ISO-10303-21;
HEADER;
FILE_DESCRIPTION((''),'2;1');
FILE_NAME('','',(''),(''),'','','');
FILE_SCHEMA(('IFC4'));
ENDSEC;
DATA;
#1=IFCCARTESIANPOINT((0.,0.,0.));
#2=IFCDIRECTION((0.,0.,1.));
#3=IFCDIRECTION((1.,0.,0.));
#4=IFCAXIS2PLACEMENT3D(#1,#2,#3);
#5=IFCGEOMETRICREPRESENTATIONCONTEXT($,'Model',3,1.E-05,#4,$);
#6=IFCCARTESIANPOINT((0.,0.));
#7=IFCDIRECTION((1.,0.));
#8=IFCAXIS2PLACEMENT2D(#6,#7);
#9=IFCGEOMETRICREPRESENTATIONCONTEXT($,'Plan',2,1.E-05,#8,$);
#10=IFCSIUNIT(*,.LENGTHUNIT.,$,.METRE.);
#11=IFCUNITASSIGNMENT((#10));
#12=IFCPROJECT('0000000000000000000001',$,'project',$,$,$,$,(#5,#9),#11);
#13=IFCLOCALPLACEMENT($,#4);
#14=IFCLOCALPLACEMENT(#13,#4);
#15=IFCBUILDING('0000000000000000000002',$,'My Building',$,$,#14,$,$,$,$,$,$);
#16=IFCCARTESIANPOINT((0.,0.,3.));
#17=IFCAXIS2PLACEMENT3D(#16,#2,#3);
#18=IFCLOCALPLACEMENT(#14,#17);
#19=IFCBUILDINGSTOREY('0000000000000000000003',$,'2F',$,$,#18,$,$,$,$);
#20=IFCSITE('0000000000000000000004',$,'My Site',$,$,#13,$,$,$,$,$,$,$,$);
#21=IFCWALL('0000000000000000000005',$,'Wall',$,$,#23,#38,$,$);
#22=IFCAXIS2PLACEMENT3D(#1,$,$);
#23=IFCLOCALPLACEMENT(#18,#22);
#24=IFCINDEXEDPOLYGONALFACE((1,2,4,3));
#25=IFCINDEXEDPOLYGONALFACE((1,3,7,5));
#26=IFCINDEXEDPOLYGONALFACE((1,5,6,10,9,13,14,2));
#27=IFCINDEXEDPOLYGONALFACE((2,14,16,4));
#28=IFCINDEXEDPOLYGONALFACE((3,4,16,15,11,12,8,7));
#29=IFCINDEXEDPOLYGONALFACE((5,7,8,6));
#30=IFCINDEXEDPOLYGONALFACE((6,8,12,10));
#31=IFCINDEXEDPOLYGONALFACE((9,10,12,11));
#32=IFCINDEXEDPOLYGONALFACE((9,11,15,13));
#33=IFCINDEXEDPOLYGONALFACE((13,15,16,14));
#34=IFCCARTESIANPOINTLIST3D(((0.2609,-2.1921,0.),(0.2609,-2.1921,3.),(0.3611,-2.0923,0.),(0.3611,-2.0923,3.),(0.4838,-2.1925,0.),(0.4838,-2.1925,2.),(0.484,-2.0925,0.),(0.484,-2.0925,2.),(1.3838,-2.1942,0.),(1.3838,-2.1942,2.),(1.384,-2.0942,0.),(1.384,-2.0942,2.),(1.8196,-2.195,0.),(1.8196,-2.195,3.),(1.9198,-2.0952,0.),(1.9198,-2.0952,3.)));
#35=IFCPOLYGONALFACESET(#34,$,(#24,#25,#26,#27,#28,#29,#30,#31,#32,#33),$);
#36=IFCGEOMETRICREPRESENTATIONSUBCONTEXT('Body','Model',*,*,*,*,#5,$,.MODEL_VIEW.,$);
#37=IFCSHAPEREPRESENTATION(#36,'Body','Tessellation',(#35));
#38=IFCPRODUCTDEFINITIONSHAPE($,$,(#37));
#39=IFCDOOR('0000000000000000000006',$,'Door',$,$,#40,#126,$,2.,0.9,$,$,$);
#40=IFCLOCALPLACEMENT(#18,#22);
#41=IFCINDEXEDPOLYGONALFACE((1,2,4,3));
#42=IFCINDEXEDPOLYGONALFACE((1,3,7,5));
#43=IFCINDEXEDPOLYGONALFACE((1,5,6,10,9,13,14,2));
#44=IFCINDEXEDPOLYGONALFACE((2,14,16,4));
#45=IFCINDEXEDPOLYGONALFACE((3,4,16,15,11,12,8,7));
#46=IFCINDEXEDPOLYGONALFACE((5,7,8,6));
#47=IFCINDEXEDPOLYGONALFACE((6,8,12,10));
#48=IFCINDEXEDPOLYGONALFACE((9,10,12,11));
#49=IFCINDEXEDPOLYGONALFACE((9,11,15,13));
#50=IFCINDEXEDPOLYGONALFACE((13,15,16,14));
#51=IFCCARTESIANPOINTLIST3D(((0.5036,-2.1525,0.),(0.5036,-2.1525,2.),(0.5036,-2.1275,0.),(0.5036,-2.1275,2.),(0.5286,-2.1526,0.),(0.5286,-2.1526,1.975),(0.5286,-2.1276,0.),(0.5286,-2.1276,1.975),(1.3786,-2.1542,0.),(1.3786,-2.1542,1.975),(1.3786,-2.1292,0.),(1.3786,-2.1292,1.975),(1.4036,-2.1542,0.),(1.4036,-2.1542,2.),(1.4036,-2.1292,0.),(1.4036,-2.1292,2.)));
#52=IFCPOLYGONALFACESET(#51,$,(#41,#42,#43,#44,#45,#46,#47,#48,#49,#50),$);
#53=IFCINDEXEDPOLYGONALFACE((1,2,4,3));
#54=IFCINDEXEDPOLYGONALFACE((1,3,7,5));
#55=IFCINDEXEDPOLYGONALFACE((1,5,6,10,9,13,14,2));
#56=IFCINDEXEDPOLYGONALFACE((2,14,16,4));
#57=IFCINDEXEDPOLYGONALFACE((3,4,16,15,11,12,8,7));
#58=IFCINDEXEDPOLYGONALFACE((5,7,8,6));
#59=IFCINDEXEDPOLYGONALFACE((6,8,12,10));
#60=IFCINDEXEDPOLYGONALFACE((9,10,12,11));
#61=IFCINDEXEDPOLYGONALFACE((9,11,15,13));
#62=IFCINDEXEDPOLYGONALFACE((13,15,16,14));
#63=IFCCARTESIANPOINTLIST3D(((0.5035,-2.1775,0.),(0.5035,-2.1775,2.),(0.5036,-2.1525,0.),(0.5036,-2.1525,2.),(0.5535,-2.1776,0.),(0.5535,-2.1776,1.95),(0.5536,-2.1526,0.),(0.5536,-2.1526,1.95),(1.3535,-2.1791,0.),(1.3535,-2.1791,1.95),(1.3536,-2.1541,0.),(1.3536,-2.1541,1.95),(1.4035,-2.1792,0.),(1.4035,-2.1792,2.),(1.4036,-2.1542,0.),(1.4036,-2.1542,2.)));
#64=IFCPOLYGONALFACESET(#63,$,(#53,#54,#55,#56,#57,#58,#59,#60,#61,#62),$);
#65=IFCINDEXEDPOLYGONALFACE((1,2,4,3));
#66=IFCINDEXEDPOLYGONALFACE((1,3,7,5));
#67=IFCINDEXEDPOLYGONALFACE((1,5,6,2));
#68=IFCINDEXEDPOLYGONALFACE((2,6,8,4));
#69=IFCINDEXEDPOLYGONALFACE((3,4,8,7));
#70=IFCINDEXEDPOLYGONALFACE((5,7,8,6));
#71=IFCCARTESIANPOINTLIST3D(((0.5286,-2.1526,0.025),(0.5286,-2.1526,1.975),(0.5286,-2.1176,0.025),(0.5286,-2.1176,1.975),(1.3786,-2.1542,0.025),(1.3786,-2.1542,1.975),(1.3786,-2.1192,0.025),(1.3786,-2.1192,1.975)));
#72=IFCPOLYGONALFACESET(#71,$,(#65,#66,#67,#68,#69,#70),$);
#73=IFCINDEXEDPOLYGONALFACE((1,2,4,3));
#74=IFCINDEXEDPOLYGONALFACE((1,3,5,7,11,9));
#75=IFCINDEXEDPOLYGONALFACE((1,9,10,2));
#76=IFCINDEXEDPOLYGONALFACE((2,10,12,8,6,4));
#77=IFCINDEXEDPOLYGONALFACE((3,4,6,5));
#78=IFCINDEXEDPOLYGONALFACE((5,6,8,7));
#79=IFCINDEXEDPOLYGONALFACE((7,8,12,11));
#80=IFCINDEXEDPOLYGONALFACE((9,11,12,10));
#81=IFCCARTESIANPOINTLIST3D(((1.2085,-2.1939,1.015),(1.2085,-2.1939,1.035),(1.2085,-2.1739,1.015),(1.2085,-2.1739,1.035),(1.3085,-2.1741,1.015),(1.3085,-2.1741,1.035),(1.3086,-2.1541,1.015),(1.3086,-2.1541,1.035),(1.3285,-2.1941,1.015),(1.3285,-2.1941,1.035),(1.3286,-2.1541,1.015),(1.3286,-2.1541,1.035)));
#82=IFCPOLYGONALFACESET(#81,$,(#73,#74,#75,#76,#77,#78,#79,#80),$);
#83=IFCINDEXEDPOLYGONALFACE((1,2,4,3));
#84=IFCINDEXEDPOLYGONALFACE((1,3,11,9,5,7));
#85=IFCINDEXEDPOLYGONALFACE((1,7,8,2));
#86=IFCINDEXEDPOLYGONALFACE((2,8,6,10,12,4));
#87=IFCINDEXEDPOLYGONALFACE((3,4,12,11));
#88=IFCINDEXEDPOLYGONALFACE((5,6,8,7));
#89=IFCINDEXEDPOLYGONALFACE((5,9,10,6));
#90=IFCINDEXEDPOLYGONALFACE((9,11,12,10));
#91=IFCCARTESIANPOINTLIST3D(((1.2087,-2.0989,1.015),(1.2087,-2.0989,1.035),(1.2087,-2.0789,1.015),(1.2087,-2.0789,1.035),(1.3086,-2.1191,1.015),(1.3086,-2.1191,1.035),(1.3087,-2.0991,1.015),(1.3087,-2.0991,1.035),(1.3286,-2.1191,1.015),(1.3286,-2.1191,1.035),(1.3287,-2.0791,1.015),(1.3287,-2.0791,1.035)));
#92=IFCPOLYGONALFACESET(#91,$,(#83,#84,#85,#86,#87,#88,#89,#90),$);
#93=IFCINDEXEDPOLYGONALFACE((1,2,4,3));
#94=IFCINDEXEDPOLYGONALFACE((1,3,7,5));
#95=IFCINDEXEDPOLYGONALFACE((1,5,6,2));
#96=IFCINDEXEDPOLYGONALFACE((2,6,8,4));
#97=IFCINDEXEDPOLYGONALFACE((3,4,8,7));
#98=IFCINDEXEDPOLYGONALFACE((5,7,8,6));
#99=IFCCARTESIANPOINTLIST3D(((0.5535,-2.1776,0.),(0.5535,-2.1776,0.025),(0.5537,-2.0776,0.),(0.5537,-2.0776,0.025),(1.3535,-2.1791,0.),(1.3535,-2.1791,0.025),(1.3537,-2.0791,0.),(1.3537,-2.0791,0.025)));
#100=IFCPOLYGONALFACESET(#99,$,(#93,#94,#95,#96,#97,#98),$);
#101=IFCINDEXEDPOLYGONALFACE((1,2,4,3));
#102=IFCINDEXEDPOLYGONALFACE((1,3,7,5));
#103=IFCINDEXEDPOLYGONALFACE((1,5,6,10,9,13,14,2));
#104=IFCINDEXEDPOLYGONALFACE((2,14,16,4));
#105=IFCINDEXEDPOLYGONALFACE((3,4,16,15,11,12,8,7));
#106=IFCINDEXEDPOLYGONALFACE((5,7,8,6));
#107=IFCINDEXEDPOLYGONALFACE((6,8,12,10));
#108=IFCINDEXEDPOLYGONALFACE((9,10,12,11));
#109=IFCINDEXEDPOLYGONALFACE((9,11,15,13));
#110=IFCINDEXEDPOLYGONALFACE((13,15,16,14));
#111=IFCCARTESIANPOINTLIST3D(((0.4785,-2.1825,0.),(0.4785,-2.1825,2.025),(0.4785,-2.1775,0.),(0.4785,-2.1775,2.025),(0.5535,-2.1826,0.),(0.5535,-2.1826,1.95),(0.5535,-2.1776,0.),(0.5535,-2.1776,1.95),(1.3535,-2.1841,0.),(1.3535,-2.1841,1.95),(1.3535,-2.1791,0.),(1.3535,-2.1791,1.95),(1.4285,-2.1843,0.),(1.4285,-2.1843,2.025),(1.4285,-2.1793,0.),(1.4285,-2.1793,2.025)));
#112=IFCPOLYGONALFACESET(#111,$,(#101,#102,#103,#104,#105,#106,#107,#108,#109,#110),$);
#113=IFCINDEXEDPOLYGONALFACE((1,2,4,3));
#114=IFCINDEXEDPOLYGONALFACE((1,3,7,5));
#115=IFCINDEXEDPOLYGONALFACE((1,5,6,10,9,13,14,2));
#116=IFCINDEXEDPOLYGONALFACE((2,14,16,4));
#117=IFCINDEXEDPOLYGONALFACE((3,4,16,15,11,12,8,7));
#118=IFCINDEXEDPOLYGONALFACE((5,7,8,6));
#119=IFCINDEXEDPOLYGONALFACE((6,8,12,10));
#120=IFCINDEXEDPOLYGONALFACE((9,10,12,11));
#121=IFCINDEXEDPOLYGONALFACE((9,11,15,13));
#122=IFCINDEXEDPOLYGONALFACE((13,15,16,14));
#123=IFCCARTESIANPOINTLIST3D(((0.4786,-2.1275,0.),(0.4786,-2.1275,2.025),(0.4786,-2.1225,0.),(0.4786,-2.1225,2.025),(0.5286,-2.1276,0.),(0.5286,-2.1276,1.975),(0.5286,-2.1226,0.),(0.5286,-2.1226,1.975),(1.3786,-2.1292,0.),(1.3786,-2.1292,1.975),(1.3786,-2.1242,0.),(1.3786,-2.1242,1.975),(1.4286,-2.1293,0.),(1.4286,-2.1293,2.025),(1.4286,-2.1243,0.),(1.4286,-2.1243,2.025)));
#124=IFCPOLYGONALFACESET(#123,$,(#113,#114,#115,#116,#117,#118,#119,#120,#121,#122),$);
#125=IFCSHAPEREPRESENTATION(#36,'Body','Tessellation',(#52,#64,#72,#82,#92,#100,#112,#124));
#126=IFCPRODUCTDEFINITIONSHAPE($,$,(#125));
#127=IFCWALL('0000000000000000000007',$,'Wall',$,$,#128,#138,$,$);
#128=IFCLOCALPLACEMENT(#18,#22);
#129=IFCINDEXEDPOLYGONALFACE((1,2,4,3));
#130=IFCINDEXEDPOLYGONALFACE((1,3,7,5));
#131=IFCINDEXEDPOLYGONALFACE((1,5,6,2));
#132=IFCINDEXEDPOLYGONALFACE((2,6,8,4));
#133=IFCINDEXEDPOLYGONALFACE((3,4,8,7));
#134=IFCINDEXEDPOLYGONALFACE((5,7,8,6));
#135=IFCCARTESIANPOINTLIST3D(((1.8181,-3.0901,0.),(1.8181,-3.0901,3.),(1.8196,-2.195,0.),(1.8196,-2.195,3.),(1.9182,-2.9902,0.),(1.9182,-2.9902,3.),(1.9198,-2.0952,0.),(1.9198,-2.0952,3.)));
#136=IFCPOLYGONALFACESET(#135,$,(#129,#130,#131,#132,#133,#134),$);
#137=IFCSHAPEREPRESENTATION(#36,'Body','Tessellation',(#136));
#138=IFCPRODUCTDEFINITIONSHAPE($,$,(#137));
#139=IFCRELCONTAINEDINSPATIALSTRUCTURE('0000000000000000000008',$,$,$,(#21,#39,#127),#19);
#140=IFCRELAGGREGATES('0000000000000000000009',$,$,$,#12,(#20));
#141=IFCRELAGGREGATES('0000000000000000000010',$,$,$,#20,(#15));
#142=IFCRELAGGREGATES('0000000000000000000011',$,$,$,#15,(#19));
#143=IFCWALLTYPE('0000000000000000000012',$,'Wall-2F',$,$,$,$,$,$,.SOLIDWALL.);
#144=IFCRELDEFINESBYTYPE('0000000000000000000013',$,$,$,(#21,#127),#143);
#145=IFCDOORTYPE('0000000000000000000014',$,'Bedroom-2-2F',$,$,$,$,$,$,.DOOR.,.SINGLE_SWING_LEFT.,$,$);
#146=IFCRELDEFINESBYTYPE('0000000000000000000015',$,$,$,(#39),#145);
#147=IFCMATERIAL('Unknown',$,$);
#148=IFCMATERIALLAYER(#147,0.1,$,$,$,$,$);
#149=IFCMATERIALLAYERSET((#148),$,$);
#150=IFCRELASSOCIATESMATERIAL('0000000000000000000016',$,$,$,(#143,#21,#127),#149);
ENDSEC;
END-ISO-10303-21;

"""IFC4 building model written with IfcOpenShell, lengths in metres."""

from ifc_helpers import new_model, entity, si_unit, frame, origin_with_axes, origin_2d_with_axis, place, context, subcontext, project, spatial, line, indexed_curve, outline, extrude, shape, source, transform, mapped, material, layer, layer_set, layer_usage, type_object, type_shapes, element, fill, save


model = new_model("IFC4")

# Units and contexts
model_context = context("Model", 3, precision=1e-05, world=origin_with_axes())
plan_context = context("Plan", 2, precision=1e-05, world=origin_2d_with_axis())
body_context_1 = subcontext(model_context, "Body", "Model", "MODEL_VIEW")
body_context_2 = subcontext(plan_context, "Body", "Plan", "PLAN_VIEW")
ifc_project = project(units=[si_unit("LENGTHUNIT", "METRE")], contexts=[model_context, plan_context])

# Site, building, storey
site_placement = place(None, origin_with_axes())
site = spatial("IfcSite", under=ifc_project, at=site_placement, Name="My Site")
building_placement = place(site_placement, origin_with_axes())
building = spatial("IfcBuilding", under=site, at=building_placement, Name="My Building")
storey_placement = place(building_placement, frame((0.0, 0.0, 3.0), z_axis=(0.0, 0.0, 1.0), x_axis=(1.0, 0.0, 0.0)))
storey = spatial("IfcBuildingStorey", under=building, at=storey_placement, Name="2F")

# Shared definitions
ifc_material = material(Name="Unknown")

# Shared definitions
ifc_layer_1 = layer(ifc_material, 0.1)
ifc_layer_set_1 = layer_set([ifc_layer_1])
wall_type = type_object("IfcWallType", Name="Wall-2F", PredefinedType="SOLIDWALL", material=ifc_layer_set_1)

# Wall, opening, door
ifc_layer_usage_1 = layer_usage(ifc_layer_set_1, "AXIS2", "POSITIVE", 0.0)
wall_1_placement = place(storey_placement, frame((0.2609, -2.1921, 0.0), z_axis=(0.0, 0.0, 1.0), x_axis=(0.999998, -0.001889, 0.0)))
wall_1 = element("IfcWall", 1, at=wall_1_placement, inside=storey, type_object=wall_type, material=ifc_layer_usage_1, Name="Wall", context=body_context_1, shape_type="SweptSolid", body=[
    extrude(outline(indexed_curve([(0.0, 0.0), (0.1, 0.1), (1.6587, 0.1), (1.5587, 0.0)], segments=[line(1, 2, 3, 4, 1)])), origin_with_axes(), (0.0, 0.0, 1.0), 3.0),
])
shared_shape_1 = source(origin_with_axes(), body_context_1, "Body", "SweptSolid", [
    extrude(outline(indexed_curve([(0.0, 0.0), (0.9, 0.0), (0.9, 2.0), (0.0, 2.0)], segments=[line(1, 2, 3, 4, 1)])), frame((0.0, -0.6, 0.0), z_axis=(0.0, -1.0, 0.0), x_axis=(1.0, 0.0, 0.0)), (0.0, 0.0, -1.0), 1.2),
])
opening_1_placement = place(wall_1_placement, frame((1.1228, 0.1, 0.0), z_axis=(0.0, 0.0, 1.0), x_axis=(-1.0, 0.0, 0.0)))
opening_1 = element("IfcOpeningElement", 2, at=opening_1_placement, cuts=wall_1, PredefinedType="OPENING", context=body_context_1, shape_type="MappedRepresentation", body=[
    mapped(shared_shape_1, transform((0.0, 0.0, 0.0), x_axis=(1.0, 0.0, 0.0), y_axis=(0.0, 1.0, 0.0), z_axis=(0.0, 0.0, 1.0), scale=1.0)),
])
door_type_1 = type_object("IfcDoorType", Name="Bedroom-2-2F", OperationType="SINGLE_SWING_LEFT", PredefinedType="DOOR")
shared_shape_2 = source(origin_with_axes(), body_context_1, "Body", "SweptSolid", [
    extrude(outline(indexed_curve([(0.0, 0.0), (0.0, 2.0), (0.9, 2.0), (0.9, 0.0), (0.875, 0.0), (0.875, 1.975), (0.025, 1.975), (0.025, 0.0)], segments=[line(1, 2, 3, 4, 5, 6, 7, 8, 1)])), frame((0.0, 0.025, 0.0), z_axis=(0.0, -1.0, 0.0), x_axis=(1.0, 0.0, 0.0)), (0.0, 0.0, -1.0), 0.025),
    extrude(outline(indexed_curve([(0.0, 0.0), (0.0, 2.0), (0.9, 2.0), (0.9, 0.0), (0.85, 0.0), (0.85, 1.95), (0.05, 1.95), (0.05, 0.0)], segments=[line(1, 2, 3, 4, 5, 6, 7, 8, 1)])), frame((0.0, 0.0, 0.0), z_axis=(0.0, -1.0, 0.0), x_axis=(1.0, 0.0, 0.0)), (0.0, 0.0, -1.0), 0.025),
    extrude(outline(indexed_curve([(0.0, 0.0), (0.85, 0.0), (0.85, 0.035), (0.0, 0.035)], segments=[line(1, 2, 3, 4, 1)])), frame((0.025, 0.025, 0.025), z_axis=(0.0, 0.0, 1.0), x_axis=(1.0, 0.0, 0.0)), (0.0, 0.0, 1.0), 1.95),
    extrude(outline(indexed_curve([(0.0, 0.0), (0.0, -0.04), (-0.12, -0.04), (-0.12, -0.02), (-0.02, -0.02), (-0.02, 0.0)], segments=[line(1, 2, 3, 4, 5, 6, 1)])), frame((0.825, 0.025, 1.015), z_axis=(0.0, 0.0, 1.0), x_axis=(1.0, 0.0, 0.0)), (0.0, 0.0, 1.0), 0.02),
    extrude(outline(indexed_curve([(0.0, 0.0), (0.0, 0.04), (-0.12, 0.04), (-0.12, 0.02), (-0.02, 0.02), (-0.02, 0.0)], segments=[line(1, 2, 3, 4, 5, 6, 1)])), frame((0.825, 0.06, 1.015), z_axis=(0.0, 0.0, 1.0), x_axis=(1.0, 0.0, 0.0)), (0.0, 0.0, 1.0), 0.02),
    extrude(outline(indexed_curve([(0.0, 0.0), (0.8, 0.0), (0.8, 0.1), (0.0, 0.1)], segments=[line(1, 2, 3, 4, 1)])), frame((0.05, 0.0, 0.0), z_axis=(0.0, 0.0, 1.0), x_axis=(1.0, 0.0, 0.0)), (0.0, 0.0, 1.0), 0.025),
    extrude(outline(indexed_curve([(0.0, 0.0), (0.0, 2.025), (0.95, 2.025), (0.95, 0.0), (0.875, 0.0), (0.875, 1.95), (0.075, 1.95), (0.075, 0.0)], segments=[line(1, 2, 3, 4, 5, 6, 7, 8, 1)])), frame((-0.025, -0.005, 0.0), z_axis=(0.0, -1.0, 0.0), x_axis=(1.0, 0.0, 0.0)), (0.0, 0.0, -1.0), 0.005),
    extrude(outline(indexed_curve([(0.0, 0.0), (0.0, 2.025), (0.95, 2.025), (0.95, 0.0), (0.9, 0.0), (0.9, 1.975), (0.05, 1.975), (0.05, 0.0)], segments=[line(1, 2, 3, 4, 5, 6, 7, 8, 1)])), frame((-0.025, 0.05, 0.0), z_axis=(0.0, -1.0, 0.0), x_axis=(1.0, 0.0, 0.0)), (0.0, 0.0, -1.0), 0.005),
])
shared_shape_3 = source(origin_with_axes(), body_context_2, "Body", "Curve2D", [
    entity("IfcIndexedPolyCurve", entity("IfcCartesianPointList2D", [[0.0, 0.0], [0.0, 0.05], [0.025, 0.05], [0.025, 0.025], [0.05, 0.025], [0.05, 0.0]]), [entity("IfcLineIndex", [1, 2, 3, 4, 5, 6, 1])]),
    entity("IfcIndexedPolyCurve", entity("IfcCartesianPointList2D", [[0.9, 0.0], [0.9, 0.05], [0.875, 0.05], [0.875, 0.025], [0.85, 0.025], [0.85, 0.0]]), [entity("IfcLineIndex", [1, 2, 3, 4, 5, 6, 1])]),
    entity("IfcTrimmedCurve", entity("IfcEllipse", entity("IfcAxis2Placement2D", entity("IfcCartesianPoint", [0.06, 0.05]), entity("IfcDirection", [1.0, 0.0])), 0.815, 0.85), [entity("IfcCartesianPoint", [0.875, 0.05])], [entity("IfcCartesianPoint", [0.06, 0.9])], True, "CARTESIAN"),
    entity("IfcIndexedPolyCurve", entity("IfcCartesianPointList2D", [[0.025, 0.05], [0.06, 0.05], [0.06, 0.9], [0.025, 0.9]]), [entity("IfcLineIndex", [1, 2, 3, 4, 1])]),
])
type_shapes(door_type_1, [shared_shape_2, shared_shape_3])
door_1_placement = place(opening_1_placement, frame((0.8803, 0.085, 0.0), z_axis=(0.0, 0.0, 1.0), x_axis=(-1.0, 0.0, 0.0)))
door_1 = element("IfcDoor", 3, at=door_1_placement, inside=storey, type_object=door_type_1, Name="Door", OverallHeight=2.0, OverallWidth=0.9, shapes=[
    shape(body_context_1, "Body", "MappedRepresentation", [mapped(shared_shape_2, transform((0.0, 0.0, 0.0), x_axis=(1.0, 0.0, 0.0), y_axis=(0.0, 1.0, 0.0), z_axis=(0.0, 0.0, 1.0), scale=1.0))]),
    shape(body_context_2, "Body", "MappedRepresentation", [mapped(shared_shape_3, transform((0.0, 0.0, 0.0), x_axis=(1.0, 0.0, 0.0), y_axis=(0.0, 1.0, 0.0), z_axis=(0.0, 0.0, 1.0), scale=1.0))]),
])
fill(opening_1, door_1)

# Wall
ifc_layer_usage_2 = layer_usage(ifc_layer_set_1, "AXIS2", "POSITIVE", 0.0)
wall_2_placement = place(storey_placement, frame((1.8196, -2.195, 0.0), z_axis=(0.0, 0.0, 1.0), x_axis=(-0.001719, -0.999999, 0.0)))
element("IfcWall", 4, at=wall_2_placement, inside=storey, type_object=wall_type, material=ifc_layer_usage_2, Name="Wall", context=body_context_1, shape_type="SweptSolid", body=[
    extrude(outline(indexed_curve([(0.0, 0.0), (-0.1, 0.1), (0.795, 0.1), (0.895, 0.0)], segments=[line(1, 2, 3, 4, 1)])), origin_with_axes(), (0.0, 0.0, 1.0), 3.0),
])

save(model, "model.ifc")
